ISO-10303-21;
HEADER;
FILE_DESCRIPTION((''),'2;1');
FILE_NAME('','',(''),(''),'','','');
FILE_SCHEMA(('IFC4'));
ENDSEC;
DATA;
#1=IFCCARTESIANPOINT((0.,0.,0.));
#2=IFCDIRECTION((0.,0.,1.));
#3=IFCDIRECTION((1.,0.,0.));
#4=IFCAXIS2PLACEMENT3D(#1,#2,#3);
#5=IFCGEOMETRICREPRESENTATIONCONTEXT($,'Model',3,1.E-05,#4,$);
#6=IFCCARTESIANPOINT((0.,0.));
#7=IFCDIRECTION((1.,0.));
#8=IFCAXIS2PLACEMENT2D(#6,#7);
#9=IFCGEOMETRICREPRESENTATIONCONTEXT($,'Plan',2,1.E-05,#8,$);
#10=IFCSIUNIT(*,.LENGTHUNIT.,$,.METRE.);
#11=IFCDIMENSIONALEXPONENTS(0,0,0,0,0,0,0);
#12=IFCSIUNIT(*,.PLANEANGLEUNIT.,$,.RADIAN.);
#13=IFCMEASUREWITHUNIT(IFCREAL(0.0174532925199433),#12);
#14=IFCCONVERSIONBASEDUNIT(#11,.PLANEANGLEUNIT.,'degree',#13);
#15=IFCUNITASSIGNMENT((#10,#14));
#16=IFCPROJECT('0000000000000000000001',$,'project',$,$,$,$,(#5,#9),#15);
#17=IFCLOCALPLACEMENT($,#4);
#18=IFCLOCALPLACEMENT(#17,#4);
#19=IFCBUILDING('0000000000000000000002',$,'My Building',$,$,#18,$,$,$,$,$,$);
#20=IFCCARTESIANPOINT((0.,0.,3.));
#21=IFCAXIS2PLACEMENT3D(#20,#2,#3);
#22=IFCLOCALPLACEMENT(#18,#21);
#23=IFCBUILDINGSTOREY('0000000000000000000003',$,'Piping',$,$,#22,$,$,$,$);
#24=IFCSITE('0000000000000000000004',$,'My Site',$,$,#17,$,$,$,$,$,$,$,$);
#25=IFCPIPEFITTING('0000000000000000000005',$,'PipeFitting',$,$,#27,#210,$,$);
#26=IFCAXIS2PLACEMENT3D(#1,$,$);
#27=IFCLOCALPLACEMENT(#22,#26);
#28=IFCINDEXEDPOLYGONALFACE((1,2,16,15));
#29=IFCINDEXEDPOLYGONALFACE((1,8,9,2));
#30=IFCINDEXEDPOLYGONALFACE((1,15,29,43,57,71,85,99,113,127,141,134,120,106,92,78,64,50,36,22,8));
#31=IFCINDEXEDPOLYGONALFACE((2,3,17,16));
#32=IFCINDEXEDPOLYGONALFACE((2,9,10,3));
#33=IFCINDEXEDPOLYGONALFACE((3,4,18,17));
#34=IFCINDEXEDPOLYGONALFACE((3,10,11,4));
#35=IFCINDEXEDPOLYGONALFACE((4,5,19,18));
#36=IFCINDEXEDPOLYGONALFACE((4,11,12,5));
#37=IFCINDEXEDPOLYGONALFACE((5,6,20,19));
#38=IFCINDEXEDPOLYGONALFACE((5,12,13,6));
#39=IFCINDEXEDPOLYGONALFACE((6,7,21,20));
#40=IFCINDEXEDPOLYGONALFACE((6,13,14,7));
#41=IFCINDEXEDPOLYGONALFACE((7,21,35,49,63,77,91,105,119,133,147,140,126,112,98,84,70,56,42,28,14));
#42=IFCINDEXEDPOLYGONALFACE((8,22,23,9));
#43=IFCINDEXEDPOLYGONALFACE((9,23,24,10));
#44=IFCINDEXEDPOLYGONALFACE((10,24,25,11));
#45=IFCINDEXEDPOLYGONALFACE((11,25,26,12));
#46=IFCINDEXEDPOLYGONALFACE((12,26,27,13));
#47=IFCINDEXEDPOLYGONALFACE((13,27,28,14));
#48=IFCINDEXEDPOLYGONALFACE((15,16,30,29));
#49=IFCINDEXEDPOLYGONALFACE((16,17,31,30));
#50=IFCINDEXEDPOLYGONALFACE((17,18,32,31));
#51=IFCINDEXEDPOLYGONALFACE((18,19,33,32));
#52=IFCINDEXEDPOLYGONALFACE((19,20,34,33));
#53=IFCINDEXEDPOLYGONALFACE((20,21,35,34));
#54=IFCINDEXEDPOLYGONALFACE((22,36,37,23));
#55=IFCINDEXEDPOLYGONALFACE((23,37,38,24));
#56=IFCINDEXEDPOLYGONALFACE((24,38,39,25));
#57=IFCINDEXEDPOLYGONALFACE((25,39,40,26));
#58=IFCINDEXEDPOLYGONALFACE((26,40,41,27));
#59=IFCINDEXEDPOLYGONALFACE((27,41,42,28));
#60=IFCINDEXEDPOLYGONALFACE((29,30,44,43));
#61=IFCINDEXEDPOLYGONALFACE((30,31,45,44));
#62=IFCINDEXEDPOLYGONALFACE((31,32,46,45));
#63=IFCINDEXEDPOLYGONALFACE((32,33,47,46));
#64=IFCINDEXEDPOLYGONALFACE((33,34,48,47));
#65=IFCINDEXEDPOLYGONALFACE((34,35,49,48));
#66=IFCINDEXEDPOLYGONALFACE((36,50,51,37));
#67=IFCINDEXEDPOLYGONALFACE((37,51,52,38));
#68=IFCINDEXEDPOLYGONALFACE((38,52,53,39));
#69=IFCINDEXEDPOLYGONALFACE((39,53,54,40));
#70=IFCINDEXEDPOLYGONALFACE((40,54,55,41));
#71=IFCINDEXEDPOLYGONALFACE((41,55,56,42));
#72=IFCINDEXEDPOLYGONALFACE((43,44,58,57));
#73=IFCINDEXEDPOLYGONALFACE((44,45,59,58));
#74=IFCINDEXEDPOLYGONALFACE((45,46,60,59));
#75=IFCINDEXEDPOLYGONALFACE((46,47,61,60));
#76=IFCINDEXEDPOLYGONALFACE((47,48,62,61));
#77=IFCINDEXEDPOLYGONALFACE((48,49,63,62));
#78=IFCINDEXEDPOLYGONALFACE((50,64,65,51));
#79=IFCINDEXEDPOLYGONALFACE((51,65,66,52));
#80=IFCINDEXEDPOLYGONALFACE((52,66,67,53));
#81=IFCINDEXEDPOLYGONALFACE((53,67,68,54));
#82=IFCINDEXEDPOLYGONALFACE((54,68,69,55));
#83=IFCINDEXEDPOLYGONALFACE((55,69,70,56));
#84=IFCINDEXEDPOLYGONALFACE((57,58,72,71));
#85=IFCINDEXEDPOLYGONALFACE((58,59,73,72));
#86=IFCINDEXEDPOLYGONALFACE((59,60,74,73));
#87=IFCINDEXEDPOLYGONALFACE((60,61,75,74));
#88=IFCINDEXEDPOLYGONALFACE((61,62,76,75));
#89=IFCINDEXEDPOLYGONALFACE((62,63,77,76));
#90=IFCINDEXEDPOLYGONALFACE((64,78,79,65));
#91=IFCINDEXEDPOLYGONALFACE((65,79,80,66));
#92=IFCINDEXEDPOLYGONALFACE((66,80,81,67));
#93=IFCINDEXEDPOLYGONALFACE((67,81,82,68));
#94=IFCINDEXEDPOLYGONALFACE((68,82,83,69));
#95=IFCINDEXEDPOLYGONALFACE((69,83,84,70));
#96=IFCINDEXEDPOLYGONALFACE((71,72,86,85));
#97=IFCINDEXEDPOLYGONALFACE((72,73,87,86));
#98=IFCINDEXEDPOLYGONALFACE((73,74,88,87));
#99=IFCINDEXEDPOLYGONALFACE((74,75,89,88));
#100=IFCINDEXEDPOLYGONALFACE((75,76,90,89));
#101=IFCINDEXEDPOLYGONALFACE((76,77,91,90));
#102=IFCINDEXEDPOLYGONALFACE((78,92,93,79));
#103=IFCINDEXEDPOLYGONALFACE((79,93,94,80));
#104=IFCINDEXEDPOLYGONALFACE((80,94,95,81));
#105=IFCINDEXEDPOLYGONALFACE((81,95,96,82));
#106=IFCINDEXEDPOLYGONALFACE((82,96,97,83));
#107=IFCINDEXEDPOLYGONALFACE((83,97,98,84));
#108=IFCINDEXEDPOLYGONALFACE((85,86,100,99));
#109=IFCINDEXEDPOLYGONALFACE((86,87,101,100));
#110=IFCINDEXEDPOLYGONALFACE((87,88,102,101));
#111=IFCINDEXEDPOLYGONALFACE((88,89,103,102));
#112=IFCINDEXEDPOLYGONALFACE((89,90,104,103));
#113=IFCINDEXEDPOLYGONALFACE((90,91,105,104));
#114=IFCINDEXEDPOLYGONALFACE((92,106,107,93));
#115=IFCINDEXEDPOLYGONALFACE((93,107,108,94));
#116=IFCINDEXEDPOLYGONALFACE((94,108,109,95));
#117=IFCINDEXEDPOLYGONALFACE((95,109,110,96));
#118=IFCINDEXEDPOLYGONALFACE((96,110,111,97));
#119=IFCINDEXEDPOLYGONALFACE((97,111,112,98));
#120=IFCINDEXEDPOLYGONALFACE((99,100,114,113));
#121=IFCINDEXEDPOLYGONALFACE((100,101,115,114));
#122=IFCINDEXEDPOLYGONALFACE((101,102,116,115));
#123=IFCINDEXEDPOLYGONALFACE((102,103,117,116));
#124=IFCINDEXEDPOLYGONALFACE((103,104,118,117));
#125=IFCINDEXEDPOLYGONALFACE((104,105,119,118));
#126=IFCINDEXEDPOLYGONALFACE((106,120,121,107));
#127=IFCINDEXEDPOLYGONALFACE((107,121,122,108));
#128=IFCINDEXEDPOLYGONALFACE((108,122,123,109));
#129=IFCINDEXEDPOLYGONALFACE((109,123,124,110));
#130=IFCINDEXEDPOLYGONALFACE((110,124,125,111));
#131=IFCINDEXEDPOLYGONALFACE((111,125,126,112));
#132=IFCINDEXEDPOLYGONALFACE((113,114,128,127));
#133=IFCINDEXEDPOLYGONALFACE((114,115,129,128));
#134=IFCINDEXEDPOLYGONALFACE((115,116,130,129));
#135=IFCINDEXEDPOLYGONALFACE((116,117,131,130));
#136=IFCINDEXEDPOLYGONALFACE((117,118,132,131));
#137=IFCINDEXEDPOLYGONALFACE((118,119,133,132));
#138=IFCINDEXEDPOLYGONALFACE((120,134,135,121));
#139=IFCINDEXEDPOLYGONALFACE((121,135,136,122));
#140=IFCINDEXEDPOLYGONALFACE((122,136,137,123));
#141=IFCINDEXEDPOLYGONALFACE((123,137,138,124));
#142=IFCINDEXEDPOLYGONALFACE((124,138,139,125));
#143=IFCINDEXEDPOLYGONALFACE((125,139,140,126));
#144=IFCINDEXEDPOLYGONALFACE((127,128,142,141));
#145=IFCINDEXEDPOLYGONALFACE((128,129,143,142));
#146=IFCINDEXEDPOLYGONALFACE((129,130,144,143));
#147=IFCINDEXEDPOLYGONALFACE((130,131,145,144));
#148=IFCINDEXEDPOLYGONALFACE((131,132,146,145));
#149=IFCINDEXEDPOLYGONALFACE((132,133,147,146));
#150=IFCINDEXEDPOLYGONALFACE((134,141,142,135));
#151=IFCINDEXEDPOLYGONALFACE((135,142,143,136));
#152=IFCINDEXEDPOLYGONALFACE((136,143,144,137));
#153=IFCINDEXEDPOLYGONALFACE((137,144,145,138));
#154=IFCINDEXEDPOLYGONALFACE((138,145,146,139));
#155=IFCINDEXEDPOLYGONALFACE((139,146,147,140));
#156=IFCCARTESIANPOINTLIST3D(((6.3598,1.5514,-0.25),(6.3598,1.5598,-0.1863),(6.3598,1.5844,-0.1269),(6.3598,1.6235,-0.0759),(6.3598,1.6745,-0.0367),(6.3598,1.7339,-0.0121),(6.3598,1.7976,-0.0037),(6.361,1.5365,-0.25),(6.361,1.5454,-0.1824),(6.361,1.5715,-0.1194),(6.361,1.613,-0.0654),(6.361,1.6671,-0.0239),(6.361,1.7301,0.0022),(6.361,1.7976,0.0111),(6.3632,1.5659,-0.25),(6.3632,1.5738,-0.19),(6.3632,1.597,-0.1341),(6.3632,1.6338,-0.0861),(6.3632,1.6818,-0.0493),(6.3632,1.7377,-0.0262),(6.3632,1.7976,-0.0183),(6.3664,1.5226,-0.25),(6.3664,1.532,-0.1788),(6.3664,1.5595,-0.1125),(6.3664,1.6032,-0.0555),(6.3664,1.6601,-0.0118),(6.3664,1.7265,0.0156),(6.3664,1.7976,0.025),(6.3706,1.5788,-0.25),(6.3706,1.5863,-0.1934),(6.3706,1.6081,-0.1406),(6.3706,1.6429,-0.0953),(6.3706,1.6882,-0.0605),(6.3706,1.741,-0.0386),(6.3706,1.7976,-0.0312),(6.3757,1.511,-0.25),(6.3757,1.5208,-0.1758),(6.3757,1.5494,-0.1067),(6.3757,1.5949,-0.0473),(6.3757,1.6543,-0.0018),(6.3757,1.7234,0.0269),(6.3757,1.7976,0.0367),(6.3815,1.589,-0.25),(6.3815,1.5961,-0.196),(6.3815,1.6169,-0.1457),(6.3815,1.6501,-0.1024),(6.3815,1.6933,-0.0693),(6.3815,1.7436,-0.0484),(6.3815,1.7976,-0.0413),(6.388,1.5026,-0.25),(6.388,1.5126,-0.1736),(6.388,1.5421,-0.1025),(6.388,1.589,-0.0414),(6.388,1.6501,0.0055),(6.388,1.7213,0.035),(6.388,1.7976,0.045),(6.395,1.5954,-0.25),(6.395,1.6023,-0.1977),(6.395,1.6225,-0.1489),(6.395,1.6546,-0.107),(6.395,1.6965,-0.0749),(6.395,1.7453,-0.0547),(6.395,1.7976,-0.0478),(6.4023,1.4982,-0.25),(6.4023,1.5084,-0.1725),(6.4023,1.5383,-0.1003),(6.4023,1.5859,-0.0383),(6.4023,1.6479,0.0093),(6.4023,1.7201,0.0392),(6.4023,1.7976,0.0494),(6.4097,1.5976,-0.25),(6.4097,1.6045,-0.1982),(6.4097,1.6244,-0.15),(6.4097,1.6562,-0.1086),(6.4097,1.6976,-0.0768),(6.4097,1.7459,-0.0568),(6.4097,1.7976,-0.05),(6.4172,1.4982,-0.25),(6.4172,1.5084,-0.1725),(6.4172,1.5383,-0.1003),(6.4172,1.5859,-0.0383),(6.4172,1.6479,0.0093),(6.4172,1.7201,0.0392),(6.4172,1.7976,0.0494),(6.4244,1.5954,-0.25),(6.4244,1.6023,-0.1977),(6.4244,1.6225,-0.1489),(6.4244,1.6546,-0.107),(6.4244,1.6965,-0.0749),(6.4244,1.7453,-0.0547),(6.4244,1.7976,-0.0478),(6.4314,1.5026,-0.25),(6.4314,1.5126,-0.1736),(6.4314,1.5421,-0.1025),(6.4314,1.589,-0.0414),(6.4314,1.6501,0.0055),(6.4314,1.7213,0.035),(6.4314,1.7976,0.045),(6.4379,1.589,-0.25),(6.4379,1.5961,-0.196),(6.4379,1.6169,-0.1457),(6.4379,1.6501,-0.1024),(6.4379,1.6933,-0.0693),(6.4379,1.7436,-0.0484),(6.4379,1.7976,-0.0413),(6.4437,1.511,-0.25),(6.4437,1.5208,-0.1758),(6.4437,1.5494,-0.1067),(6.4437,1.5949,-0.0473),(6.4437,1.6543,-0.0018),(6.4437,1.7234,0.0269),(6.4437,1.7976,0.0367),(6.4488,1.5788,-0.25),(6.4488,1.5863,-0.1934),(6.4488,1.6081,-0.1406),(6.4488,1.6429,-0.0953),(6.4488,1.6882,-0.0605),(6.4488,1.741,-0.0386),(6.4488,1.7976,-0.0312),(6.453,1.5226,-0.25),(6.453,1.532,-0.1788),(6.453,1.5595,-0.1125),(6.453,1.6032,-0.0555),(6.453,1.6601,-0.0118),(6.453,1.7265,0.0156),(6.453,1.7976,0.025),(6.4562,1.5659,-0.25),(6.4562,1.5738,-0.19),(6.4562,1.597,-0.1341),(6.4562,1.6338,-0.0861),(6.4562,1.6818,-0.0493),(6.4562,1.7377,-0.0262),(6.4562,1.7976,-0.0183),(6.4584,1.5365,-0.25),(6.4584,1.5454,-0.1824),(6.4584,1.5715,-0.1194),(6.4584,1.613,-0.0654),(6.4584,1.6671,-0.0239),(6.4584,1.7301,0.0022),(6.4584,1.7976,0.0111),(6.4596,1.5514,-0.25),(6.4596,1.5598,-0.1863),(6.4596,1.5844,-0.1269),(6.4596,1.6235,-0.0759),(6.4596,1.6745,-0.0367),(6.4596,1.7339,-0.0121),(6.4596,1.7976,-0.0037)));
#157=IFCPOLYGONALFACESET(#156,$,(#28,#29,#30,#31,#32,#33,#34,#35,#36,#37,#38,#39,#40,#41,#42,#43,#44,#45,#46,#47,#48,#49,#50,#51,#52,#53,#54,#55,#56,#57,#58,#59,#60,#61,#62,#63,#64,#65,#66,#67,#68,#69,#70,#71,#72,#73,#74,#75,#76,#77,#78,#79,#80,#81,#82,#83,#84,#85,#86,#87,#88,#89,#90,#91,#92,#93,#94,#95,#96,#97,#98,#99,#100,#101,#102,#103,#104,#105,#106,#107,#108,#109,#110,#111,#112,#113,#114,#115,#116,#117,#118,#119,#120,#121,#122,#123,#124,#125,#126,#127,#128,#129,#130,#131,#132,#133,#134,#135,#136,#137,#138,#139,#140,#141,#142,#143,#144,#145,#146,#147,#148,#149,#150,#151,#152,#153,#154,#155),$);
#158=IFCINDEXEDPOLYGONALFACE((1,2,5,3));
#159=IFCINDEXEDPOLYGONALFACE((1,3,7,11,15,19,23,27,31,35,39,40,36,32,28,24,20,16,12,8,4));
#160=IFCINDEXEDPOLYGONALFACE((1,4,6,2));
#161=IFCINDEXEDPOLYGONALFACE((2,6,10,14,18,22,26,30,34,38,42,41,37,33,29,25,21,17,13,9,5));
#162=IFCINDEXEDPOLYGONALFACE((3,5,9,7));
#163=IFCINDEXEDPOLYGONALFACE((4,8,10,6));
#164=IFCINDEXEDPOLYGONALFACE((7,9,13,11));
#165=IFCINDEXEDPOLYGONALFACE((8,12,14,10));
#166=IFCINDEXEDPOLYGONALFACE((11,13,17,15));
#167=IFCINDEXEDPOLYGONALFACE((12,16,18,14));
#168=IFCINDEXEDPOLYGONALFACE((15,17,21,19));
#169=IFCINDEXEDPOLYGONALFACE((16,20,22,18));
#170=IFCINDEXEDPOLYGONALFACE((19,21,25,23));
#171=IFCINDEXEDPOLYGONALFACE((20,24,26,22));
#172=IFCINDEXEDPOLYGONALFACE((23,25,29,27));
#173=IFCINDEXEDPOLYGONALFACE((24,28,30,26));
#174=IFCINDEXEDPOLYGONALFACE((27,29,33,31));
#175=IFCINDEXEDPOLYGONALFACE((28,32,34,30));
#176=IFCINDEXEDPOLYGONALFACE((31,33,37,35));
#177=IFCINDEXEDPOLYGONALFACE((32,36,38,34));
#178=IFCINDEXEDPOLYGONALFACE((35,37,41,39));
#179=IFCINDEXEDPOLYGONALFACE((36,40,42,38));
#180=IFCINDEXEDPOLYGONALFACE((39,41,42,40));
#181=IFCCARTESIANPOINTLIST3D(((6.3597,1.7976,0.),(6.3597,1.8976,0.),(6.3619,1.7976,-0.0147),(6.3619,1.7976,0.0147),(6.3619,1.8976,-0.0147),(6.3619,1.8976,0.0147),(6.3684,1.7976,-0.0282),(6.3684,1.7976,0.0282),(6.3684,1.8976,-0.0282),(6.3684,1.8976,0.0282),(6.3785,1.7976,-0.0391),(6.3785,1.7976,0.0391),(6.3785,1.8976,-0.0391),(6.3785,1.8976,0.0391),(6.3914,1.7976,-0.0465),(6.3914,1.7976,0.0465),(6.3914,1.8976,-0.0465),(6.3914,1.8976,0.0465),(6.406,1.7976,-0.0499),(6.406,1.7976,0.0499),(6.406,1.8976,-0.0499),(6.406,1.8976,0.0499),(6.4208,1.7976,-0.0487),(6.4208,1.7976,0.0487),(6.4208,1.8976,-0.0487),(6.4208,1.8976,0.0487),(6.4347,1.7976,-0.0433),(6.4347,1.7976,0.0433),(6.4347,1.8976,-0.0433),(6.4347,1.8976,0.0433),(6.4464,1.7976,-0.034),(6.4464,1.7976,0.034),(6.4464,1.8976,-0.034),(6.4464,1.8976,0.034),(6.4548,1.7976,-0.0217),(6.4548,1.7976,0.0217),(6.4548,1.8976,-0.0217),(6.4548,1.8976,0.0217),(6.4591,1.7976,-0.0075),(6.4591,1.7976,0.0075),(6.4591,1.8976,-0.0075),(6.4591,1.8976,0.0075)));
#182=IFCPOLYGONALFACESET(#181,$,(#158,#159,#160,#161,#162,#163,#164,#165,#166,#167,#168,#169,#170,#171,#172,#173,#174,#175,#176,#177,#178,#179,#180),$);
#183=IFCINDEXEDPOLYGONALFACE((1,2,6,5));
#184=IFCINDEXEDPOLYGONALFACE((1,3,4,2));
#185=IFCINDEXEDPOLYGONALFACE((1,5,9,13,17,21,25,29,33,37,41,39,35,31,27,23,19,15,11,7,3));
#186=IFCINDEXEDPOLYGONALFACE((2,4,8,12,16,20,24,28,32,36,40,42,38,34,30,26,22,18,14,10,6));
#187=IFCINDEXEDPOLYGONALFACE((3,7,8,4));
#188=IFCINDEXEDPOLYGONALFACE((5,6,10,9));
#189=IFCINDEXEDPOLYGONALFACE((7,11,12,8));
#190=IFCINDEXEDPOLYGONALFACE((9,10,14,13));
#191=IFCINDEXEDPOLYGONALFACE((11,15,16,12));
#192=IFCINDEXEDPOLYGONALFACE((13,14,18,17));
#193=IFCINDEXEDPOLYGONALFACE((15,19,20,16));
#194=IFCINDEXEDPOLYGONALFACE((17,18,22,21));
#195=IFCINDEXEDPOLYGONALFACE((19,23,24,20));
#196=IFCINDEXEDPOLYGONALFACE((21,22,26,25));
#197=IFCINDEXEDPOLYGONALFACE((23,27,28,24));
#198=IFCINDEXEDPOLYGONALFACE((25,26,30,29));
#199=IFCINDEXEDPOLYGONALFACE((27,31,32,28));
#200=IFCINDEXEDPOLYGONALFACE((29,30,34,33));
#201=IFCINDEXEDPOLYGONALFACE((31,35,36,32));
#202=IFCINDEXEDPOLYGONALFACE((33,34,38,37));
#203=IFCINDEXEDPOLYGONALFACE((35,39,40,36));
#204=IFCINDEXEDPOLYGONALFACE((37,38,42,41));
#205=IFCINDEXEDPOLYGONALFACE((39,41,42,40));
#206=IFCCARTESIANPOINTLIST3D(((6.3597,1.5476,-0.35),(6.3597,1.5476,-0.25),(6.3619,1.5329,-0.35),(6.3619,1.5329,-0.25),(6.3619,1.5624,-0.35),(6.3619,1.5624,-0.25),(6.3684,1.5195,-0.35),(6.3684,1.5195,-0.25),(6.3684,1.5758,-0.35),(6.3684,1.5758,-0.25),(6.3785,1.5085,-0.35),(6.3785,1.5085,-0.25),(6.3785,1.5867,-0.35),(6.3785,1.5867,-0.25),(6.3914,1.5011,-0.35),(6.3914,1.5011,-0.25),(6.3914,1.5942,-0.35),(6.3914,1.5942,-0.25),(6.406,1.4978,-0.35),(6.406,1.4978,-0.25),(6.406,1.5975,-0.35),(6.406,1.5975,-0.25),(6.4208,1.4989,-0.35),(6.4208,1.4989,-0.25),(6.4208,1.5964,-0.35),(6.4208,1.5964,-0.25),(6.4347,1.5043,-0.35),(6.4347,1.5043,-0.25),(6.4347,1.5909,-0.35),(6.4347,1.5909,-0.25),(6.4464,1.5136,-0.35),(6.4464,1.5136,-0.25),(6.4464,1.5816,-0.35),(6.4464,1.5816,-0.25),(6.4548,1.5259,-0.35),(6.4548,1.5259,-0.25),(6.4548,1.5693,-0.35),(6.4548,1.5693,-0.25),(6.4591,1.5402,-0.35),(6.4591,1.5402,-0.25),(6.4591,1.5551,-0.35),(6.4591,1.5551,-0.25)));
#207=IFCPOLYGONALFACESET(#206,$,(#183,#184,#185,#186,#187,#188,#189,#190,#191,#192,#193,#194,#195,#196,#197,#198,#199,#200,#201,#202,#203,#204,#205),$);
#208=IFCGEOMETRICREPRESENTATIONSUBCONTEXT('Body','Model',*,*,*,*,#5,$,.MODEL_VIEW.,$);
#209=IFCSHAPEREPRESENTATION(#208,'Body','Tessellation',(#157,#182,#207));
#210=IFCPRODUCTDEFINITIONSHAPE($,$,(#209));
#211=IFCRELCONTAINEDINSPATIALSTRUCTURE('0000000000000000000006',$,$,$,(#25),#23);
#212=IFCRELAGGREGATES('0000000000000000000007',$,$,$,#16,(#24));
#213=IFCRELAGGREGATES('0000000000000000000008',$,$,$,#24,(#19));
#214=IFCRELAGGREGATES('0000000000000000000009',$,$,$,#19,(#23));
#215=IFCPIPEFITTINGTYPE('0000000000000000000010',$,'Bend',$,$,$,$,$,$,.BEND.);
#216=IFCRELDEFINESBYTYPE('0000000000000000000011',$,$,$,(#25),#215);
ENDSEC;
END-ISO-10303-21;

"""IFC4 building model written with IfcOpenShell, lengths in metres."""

from ifc_helpers import new_model, entity, si_unit, converted_unit, frame, origin_with_axes, origin_2d_with_axis, place, context, subcontext, project, spatial, circle, extrude, source, transform, mapped, type_object, type_shapes, element, save


model = new_model("IFC4")

# Units and contexts
model_context = context("Model", 3, precision=1e-05, world=origin_with_axes())
plan_context = context("Plan", 2, precision=1e-05, world=origin_2d_with_axis())
body_context = subcontext(model_context, "Body", "Model", "MODEL_VIEW")
ifc_project = project(units=[si_unit("LENGTHUNIT", "METRE"), converted_unit("PLANEANGLEUNIT", "degree", entity("IfcReal", 0.0174532925199433), si_unit("PLANEANGLEUNIT", "RADIAN"), dimensions=[0, 0, 0, 0, 0, 0, 0])], contexts=[model_context, plan_context])

# Site, building, storey
site_placement = place(None, origin_with_axes())
site = spatial("IfcSite", under=ifc_project, at=site_placement, Name="My Site")
building_placement = place(site_placement, origin_with_axes())
building = spatial("IfcBuilding", under=site, at=building_placement, Name="My Building")
storey_placement = place(building_placement, frame((0.0, 0.0, 3.0), z_axis=(0.0, 0.0, 1.0), x_axis=(1.0, 0.0, 0.0)))
storey = spatial("IfcBuildingStorey", under=building, at=storey_placement, Name="Piping")

# Shared definitions
pipe_fitting_type_1 = type_object("IfcPipeFittingType", Name="Bend", PredefinedType="BEND")
shared_shape = source(origin_with_axes(), body_context, "Body", "SolidModel", [
    entity("IfcSweptDiskSolid", entity("IfcIndexedPolyCurve", entity("IfcCartesianPointList3D", [[0.0, 0.0, -0.1], [0.0, -0.0732, -0.2768], [0.0, -0.25, -0.35]]), [entity("IfcArcIndex", [1, 2, 3])]), 0.05),
    extrude(circle(Radius=0.05), origin_with_axes(), (0.0, 0.0, -1.0), 0.1),
    extrude(circle(Radius=0.05), frame((0.0, -0.25, -0.35), z_axis=(0.0, -1.0, 0.0), x_axis=(1.0, 0.0, 0.0)), (0.0, 0.0, 1.0), 0.1),
])
type_shapes(pipe_fitting_type_1, [shared_shape])

# Pipe fitting
for number, where, z_axis, x_axis, name in (
    (1, (6.4097, 1.8976, 0.0), (0.0, 1.0, 0.0), (-1.0, 0.0, 0.0), "PipeFitting"),
):
    element("IfcPipeFitting", number, at=place(storey_placement, frame(where, z_axis=z_axis, x_axis=x_axis)), inside=storey, type_object=pipe_fitting_type_1, Name=name, context=body_context, shape_type="MappedRepresentation", body=[
        mapped(shared_shape, transform((0.0, 0.0, 0.0), x_axis=(1.0, 0.0, 0.0), y_axis=(0.0, 1.0, 0.0), z_axis=(0.0, 0.0, 1.0), scale=1.0)),
    ])

save(model, "model.ifc")
